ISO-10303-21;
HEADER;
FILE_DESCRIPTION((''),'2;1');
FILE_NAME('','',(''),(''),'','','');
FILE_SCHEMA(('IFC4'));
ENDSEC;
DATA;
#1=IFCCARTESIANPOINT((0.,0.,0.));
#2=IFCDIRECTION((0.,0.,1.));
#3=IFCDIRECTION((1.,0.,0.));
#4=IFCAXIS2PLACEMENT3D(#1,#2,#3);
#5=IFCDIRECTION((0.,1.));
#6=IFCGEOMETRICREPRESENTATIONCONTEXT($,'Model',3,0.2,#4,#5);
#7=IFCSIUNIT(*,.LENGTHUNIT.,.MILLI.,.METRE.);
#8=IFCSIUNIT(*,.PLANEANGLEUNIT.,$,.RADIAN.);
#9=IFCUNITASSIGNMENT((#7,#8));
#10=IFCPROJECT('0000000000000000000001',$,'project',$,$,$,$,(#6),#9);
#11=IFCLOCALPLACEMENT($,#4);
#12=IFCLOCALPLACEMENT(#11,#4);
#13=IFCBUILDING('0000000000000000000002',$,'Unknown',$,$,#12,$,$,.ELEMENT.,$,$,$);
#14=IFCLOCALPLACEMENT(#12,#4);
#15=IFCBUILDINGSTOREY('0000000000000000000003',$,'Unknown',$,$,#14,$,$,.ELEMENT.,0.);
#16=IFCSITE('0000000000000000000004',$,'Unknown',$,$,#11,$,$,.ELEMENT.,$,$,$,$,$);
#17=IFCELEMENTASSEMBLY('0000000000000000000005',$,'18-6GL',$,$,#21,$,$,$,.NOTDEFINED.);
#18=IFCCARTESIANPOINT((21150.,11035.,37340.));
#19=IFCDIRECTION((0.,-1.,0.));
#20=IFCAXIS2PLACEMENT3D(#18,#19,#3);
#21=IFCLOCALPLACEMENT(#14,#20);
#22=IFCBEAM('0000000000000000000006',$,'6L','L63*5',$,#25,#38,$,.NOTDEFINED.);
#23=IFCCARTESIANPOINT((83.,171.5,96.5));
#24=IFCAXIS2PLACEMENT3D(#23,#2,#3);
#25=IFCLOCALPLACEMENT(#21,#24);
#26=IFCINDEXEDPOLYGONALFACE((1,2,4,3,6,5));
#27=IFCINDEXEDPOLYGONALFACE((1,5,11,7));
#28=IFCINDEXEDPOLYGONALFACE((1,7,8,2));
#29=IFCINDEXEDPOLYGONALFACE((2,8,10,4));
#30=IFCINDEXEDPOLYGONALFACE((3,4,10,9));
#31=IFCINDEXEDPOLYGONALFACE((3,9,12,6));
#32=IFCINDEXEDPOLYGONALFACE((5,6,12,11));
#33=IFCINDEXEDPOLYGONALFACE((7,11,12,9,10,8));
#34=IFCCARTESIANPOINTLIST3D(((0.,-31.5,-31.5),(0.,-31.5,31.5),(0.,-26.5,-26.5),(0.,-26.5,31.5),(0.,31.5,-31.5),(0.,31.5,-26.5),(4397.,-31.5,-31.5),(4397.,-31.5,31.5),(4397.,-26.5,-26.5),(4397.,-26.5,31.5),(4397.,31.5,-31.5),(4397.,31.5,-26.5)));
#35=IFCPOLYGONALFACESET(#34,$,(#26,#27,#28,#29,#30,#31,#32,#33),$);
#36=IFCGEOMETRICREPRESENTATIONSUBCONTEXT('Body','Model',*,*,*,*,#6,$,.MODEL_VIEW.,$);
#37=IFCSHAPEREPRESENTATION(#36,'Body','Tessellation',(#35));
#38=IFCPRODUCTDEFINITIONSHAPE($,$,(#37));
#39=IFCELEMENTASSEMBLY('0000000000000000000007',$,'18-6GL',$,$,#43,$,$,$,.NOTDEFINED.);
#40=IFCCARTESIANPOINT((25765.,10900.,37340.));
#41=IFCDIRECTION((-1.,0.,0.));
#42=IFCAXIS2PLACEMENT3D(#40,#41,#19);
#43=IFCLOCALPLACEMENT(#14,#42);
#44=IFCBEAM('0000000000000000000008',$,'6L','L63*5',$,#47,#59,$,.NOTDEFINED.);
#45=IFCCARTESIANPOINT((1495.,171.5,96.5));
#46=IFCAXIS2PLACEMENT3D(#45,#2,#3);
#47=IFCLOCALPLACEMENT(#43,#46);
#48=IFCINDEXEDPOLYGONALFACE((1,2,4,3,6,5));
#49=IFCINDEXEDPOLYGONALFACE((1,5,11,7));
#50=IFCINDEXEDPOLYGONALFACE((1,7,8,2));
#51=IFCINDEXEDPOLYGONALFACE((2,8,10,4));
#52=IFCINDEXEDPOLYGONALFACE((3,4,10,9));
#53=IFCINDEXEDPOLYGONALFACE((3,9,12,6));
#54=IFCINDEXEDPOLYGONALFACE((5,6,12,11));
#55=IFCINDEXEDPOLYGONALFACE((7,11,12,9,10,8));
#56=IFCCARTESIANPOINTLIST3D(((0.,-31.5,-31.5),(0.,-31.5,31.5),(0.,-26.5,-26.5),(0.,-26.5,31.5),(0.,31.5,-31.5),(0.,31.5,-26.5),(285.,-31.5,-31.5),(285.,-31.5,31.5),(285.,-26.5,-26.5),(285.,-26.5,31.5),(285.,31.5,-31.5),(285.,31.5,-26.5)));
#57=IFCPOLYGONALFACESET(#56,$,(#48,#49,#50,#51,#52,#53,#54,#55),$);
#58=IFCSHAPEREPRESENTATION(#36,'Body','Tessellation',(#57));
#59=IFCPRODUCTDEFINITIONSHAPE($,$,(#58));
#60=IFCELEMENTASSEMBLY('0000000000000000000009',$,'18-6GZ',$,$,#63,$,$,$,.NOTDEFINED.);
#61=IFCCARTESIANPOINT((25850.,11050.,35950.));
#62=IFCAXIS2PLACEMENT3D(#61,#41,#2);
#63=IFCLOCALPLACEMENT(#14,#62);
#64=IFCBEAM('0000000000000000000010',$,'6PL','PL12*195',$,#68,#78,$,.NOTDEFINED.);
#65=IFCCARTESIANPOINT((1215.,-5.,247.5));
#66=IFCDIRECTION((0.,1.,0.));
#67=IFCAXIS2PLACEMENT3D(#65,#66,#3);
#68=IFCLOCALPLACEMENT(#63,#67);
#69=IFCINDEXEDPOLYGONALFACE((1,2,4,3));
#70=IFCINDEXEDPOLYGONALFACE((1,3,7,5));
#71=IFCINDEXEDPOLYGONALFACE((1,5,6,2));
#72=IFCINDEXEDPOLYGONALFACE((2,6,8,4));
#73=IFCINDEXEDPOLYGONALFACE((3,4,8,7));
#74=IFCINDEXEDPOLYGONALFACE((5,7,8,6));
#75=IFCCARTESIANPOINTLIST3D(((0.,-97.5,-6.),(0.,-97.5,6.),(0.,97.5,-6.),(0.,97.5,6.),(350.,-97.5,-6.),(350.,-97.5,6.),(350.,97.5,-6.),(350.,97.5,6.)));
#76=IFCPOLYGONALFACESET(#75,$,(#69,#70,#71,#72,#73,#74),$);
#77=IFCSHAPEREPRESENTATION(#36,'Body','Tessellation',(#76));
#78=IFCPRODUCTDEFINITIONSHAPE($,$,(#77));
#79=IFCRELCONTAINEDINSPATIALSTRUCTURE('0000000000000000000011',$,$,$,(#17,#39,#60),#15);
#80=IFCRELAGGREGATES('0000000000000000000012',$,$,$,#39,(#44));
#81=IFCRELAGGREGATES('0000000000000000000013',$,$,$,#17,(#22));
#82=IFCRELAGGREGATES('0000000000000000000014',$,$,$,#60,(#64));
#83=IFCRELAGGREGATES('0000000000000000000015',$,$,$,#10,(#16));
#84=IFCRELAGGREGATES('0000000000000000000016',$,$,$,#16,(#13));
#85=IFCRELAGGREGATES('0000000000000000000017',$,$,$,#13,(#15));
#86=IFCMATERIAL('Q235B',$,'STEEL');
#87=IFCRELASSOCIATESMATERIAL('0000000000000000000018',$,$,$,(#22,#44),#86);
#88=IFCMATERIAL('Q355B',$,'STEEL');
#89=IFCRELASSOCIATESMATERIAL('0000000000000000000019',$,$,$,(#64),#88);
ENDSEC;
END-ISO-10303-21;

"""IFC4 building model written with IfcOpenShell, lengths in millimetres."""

from ifc_helpers import new_model, si_unit, direction, frame, origin_with_axes, place, context, subcontext, project, spatial, line, indexed_curve, outline, extrude, material, element, aggregate, save


model = new_model("IFC4")

# Units and contexts
model_context = context("Model", 3, precision=0.2, world=origin_with_axes(), true_north=direction((0.0, 1.0)))
body_context = subcontext(model_context, "Body", "Model", "MODEL_VIEW")
ifc_project = project(units=[si_unit("LENGTHUNIT", "METRE", prefix="MILLI"), si_unit("PLANEANGLEUNIT", "RADIAN")], contexts=[model_context])

# Site, building, storey
site_placement = place(None, origin_with_axes())
site = spatial("IfcSite", under=ifc_project, at=site_placement, Name="Unknown", CompositionType="ELEMENT")
building_placement = place(site_placement, origin_with_axes())
building = spatial("IfcBuilding", under=site, at=building_placement, Name="Unknown", CompositionType="ELEMENT")
storey_placement = place(building_placement, origin_with_axes())
storey = spatial("IfcBuildingStorey", under=building, at=storey_placement, Name="Unknown", CompositionType="ELEMENT", Elevation=0.0)

# Element assemblies, beams
assembly_1_placement = place(storey_placement, frame((21150.0, 11035.0, 37340.0), z_axis=(0.0, -1.0, 0.0), x_axis=(1.0, 0.0, 0.0)))
assembly_1 = element("IfcElementAssembly", 1, at=assembly_1_placement, inside=storey, Name="18-6GL", PredefinedType="NOTDEFINED")
ifc_material_1 = material(Name="Q235B", Category="STEEL")
beam_1_placement = place(assembly_1_placement, frame((83.0, 171.5, 96.5), z_axis=(0.0, 0.0, 1.0), x_axis=(1.0, 0.0, 0.0)))
beam_1 = element("IfcBeam", 2, at=beam_1_placement, material=ifc_material_1, Name="6L", Description="L63*5", PredefinedType="NOTDEFINED", context=body_context, shape_type="SolidModel", body=[
    extrude(outline(indexed_curve([(-31.5, -31.5), (31.5, -31.5), (31.5, -26.5), (-26.5, -26.5), (-26.5, 31.5), (-31.5, 31.5)], segments=[line(1, 2, 3, 4, 5, 6, 1)])), frame((0.0, 0.0, 0.0), z_axis=(-1.0, 0.0, 0.0), x_axis=(0.0, 0.0, 1.0)), (0.0, 0.0, -1.0), 4397.0),
])
assembly_2_placement = place(storey_placement, frame((25765.0, 10900.0, 37340.0), z_axis=(-1.0, 0.0, 0.0), x_axis=(0.0, -1.0, 0.0)))
assembly_2 = element("IfcElementAssembly", 3, at=assembly_2_placement, inside=storey, Name="18-6GL", PredefinedType="NOTDEFINED")
beam_2_placement = place(assembly_2_placement, frame((1495.0, 171.5, 96.5), z_axis=(0.0, 0.0, 1.0), x_axis=(1.0, 0.0, 0.0)))
beam_2 = element("IfcBeam", 4, at=beam_2_placement, material=ifc_material_1, Name="6L", Description="L63*5", PredefinedType="NOTDEFINED", context=body_context, shape_type="SolidModel", body=[
    extrude(outline(indexed_curve([(-31.5, -31.5), (31.5, -31.5), (31.5, -26.5), (-26.5, -26.5), (-26.5, 31.5), (-31.5, 31.5)], segments=[line(1, 2, 3, 4, 5, 6, 1)])), frame((0.0, 0.0, 0.0), z_axis=(-1.0, 0.0, 0.0), x_axis=(0.0, 0.0, 1.0)), (0.0, 0.0, -1.0), 285.0),
])
aggregate(assembly_2, [beam_2])
ifc_material_2 = material(Name="Q355B", Category="STEEL")
assembly_3_placement = place(storey_placement, frame((25850.0, 11050.0, 35950.0), z_axis=(-1.0, 0.0, 0.0), x_axis=(0.0, 0.0, 1.0)))
assembly_3 = element("IfcElementAssembly", 5, at=assembly_3_placement, inside=storey, Name="18-6GZ", PredefinedType="NOTDEFINED")
beam_3_placement = place(assembly_3_placement, frame((1215.0, -5.0, 247.5), z_axis=(0.0, 1.0, 0.0), x_axis=(1.0, 0.0, 0.0)))
beam_3 = element("IfcBeam", 6, at=beam_3_placement, material=ifc_material_2, Name="6PL", Description="PL12*195", PredefinedType="NOTDEFINED", context=body_context, shape_type="SolidModel", body=[
    extrude(outline(indexed_curve([(-6.0, -97.5), (6.0, -97.5), (6.0, 97.5), (-6.0, 97.5)], segments=[line(1, 2, 3, 4, 1)])), frame((0.0, 0.0, 0.0), z_axis=(-1.0, 0.0, 0.0), x_axis=(0.0, 0.0, 1.0)), (0.0, 0.0, -1.0), 350.0),
])

aggregate(assembly_1, [beam_1])

aggregate(assembly_3, [beam_3])

save(model, "model.ifc")
